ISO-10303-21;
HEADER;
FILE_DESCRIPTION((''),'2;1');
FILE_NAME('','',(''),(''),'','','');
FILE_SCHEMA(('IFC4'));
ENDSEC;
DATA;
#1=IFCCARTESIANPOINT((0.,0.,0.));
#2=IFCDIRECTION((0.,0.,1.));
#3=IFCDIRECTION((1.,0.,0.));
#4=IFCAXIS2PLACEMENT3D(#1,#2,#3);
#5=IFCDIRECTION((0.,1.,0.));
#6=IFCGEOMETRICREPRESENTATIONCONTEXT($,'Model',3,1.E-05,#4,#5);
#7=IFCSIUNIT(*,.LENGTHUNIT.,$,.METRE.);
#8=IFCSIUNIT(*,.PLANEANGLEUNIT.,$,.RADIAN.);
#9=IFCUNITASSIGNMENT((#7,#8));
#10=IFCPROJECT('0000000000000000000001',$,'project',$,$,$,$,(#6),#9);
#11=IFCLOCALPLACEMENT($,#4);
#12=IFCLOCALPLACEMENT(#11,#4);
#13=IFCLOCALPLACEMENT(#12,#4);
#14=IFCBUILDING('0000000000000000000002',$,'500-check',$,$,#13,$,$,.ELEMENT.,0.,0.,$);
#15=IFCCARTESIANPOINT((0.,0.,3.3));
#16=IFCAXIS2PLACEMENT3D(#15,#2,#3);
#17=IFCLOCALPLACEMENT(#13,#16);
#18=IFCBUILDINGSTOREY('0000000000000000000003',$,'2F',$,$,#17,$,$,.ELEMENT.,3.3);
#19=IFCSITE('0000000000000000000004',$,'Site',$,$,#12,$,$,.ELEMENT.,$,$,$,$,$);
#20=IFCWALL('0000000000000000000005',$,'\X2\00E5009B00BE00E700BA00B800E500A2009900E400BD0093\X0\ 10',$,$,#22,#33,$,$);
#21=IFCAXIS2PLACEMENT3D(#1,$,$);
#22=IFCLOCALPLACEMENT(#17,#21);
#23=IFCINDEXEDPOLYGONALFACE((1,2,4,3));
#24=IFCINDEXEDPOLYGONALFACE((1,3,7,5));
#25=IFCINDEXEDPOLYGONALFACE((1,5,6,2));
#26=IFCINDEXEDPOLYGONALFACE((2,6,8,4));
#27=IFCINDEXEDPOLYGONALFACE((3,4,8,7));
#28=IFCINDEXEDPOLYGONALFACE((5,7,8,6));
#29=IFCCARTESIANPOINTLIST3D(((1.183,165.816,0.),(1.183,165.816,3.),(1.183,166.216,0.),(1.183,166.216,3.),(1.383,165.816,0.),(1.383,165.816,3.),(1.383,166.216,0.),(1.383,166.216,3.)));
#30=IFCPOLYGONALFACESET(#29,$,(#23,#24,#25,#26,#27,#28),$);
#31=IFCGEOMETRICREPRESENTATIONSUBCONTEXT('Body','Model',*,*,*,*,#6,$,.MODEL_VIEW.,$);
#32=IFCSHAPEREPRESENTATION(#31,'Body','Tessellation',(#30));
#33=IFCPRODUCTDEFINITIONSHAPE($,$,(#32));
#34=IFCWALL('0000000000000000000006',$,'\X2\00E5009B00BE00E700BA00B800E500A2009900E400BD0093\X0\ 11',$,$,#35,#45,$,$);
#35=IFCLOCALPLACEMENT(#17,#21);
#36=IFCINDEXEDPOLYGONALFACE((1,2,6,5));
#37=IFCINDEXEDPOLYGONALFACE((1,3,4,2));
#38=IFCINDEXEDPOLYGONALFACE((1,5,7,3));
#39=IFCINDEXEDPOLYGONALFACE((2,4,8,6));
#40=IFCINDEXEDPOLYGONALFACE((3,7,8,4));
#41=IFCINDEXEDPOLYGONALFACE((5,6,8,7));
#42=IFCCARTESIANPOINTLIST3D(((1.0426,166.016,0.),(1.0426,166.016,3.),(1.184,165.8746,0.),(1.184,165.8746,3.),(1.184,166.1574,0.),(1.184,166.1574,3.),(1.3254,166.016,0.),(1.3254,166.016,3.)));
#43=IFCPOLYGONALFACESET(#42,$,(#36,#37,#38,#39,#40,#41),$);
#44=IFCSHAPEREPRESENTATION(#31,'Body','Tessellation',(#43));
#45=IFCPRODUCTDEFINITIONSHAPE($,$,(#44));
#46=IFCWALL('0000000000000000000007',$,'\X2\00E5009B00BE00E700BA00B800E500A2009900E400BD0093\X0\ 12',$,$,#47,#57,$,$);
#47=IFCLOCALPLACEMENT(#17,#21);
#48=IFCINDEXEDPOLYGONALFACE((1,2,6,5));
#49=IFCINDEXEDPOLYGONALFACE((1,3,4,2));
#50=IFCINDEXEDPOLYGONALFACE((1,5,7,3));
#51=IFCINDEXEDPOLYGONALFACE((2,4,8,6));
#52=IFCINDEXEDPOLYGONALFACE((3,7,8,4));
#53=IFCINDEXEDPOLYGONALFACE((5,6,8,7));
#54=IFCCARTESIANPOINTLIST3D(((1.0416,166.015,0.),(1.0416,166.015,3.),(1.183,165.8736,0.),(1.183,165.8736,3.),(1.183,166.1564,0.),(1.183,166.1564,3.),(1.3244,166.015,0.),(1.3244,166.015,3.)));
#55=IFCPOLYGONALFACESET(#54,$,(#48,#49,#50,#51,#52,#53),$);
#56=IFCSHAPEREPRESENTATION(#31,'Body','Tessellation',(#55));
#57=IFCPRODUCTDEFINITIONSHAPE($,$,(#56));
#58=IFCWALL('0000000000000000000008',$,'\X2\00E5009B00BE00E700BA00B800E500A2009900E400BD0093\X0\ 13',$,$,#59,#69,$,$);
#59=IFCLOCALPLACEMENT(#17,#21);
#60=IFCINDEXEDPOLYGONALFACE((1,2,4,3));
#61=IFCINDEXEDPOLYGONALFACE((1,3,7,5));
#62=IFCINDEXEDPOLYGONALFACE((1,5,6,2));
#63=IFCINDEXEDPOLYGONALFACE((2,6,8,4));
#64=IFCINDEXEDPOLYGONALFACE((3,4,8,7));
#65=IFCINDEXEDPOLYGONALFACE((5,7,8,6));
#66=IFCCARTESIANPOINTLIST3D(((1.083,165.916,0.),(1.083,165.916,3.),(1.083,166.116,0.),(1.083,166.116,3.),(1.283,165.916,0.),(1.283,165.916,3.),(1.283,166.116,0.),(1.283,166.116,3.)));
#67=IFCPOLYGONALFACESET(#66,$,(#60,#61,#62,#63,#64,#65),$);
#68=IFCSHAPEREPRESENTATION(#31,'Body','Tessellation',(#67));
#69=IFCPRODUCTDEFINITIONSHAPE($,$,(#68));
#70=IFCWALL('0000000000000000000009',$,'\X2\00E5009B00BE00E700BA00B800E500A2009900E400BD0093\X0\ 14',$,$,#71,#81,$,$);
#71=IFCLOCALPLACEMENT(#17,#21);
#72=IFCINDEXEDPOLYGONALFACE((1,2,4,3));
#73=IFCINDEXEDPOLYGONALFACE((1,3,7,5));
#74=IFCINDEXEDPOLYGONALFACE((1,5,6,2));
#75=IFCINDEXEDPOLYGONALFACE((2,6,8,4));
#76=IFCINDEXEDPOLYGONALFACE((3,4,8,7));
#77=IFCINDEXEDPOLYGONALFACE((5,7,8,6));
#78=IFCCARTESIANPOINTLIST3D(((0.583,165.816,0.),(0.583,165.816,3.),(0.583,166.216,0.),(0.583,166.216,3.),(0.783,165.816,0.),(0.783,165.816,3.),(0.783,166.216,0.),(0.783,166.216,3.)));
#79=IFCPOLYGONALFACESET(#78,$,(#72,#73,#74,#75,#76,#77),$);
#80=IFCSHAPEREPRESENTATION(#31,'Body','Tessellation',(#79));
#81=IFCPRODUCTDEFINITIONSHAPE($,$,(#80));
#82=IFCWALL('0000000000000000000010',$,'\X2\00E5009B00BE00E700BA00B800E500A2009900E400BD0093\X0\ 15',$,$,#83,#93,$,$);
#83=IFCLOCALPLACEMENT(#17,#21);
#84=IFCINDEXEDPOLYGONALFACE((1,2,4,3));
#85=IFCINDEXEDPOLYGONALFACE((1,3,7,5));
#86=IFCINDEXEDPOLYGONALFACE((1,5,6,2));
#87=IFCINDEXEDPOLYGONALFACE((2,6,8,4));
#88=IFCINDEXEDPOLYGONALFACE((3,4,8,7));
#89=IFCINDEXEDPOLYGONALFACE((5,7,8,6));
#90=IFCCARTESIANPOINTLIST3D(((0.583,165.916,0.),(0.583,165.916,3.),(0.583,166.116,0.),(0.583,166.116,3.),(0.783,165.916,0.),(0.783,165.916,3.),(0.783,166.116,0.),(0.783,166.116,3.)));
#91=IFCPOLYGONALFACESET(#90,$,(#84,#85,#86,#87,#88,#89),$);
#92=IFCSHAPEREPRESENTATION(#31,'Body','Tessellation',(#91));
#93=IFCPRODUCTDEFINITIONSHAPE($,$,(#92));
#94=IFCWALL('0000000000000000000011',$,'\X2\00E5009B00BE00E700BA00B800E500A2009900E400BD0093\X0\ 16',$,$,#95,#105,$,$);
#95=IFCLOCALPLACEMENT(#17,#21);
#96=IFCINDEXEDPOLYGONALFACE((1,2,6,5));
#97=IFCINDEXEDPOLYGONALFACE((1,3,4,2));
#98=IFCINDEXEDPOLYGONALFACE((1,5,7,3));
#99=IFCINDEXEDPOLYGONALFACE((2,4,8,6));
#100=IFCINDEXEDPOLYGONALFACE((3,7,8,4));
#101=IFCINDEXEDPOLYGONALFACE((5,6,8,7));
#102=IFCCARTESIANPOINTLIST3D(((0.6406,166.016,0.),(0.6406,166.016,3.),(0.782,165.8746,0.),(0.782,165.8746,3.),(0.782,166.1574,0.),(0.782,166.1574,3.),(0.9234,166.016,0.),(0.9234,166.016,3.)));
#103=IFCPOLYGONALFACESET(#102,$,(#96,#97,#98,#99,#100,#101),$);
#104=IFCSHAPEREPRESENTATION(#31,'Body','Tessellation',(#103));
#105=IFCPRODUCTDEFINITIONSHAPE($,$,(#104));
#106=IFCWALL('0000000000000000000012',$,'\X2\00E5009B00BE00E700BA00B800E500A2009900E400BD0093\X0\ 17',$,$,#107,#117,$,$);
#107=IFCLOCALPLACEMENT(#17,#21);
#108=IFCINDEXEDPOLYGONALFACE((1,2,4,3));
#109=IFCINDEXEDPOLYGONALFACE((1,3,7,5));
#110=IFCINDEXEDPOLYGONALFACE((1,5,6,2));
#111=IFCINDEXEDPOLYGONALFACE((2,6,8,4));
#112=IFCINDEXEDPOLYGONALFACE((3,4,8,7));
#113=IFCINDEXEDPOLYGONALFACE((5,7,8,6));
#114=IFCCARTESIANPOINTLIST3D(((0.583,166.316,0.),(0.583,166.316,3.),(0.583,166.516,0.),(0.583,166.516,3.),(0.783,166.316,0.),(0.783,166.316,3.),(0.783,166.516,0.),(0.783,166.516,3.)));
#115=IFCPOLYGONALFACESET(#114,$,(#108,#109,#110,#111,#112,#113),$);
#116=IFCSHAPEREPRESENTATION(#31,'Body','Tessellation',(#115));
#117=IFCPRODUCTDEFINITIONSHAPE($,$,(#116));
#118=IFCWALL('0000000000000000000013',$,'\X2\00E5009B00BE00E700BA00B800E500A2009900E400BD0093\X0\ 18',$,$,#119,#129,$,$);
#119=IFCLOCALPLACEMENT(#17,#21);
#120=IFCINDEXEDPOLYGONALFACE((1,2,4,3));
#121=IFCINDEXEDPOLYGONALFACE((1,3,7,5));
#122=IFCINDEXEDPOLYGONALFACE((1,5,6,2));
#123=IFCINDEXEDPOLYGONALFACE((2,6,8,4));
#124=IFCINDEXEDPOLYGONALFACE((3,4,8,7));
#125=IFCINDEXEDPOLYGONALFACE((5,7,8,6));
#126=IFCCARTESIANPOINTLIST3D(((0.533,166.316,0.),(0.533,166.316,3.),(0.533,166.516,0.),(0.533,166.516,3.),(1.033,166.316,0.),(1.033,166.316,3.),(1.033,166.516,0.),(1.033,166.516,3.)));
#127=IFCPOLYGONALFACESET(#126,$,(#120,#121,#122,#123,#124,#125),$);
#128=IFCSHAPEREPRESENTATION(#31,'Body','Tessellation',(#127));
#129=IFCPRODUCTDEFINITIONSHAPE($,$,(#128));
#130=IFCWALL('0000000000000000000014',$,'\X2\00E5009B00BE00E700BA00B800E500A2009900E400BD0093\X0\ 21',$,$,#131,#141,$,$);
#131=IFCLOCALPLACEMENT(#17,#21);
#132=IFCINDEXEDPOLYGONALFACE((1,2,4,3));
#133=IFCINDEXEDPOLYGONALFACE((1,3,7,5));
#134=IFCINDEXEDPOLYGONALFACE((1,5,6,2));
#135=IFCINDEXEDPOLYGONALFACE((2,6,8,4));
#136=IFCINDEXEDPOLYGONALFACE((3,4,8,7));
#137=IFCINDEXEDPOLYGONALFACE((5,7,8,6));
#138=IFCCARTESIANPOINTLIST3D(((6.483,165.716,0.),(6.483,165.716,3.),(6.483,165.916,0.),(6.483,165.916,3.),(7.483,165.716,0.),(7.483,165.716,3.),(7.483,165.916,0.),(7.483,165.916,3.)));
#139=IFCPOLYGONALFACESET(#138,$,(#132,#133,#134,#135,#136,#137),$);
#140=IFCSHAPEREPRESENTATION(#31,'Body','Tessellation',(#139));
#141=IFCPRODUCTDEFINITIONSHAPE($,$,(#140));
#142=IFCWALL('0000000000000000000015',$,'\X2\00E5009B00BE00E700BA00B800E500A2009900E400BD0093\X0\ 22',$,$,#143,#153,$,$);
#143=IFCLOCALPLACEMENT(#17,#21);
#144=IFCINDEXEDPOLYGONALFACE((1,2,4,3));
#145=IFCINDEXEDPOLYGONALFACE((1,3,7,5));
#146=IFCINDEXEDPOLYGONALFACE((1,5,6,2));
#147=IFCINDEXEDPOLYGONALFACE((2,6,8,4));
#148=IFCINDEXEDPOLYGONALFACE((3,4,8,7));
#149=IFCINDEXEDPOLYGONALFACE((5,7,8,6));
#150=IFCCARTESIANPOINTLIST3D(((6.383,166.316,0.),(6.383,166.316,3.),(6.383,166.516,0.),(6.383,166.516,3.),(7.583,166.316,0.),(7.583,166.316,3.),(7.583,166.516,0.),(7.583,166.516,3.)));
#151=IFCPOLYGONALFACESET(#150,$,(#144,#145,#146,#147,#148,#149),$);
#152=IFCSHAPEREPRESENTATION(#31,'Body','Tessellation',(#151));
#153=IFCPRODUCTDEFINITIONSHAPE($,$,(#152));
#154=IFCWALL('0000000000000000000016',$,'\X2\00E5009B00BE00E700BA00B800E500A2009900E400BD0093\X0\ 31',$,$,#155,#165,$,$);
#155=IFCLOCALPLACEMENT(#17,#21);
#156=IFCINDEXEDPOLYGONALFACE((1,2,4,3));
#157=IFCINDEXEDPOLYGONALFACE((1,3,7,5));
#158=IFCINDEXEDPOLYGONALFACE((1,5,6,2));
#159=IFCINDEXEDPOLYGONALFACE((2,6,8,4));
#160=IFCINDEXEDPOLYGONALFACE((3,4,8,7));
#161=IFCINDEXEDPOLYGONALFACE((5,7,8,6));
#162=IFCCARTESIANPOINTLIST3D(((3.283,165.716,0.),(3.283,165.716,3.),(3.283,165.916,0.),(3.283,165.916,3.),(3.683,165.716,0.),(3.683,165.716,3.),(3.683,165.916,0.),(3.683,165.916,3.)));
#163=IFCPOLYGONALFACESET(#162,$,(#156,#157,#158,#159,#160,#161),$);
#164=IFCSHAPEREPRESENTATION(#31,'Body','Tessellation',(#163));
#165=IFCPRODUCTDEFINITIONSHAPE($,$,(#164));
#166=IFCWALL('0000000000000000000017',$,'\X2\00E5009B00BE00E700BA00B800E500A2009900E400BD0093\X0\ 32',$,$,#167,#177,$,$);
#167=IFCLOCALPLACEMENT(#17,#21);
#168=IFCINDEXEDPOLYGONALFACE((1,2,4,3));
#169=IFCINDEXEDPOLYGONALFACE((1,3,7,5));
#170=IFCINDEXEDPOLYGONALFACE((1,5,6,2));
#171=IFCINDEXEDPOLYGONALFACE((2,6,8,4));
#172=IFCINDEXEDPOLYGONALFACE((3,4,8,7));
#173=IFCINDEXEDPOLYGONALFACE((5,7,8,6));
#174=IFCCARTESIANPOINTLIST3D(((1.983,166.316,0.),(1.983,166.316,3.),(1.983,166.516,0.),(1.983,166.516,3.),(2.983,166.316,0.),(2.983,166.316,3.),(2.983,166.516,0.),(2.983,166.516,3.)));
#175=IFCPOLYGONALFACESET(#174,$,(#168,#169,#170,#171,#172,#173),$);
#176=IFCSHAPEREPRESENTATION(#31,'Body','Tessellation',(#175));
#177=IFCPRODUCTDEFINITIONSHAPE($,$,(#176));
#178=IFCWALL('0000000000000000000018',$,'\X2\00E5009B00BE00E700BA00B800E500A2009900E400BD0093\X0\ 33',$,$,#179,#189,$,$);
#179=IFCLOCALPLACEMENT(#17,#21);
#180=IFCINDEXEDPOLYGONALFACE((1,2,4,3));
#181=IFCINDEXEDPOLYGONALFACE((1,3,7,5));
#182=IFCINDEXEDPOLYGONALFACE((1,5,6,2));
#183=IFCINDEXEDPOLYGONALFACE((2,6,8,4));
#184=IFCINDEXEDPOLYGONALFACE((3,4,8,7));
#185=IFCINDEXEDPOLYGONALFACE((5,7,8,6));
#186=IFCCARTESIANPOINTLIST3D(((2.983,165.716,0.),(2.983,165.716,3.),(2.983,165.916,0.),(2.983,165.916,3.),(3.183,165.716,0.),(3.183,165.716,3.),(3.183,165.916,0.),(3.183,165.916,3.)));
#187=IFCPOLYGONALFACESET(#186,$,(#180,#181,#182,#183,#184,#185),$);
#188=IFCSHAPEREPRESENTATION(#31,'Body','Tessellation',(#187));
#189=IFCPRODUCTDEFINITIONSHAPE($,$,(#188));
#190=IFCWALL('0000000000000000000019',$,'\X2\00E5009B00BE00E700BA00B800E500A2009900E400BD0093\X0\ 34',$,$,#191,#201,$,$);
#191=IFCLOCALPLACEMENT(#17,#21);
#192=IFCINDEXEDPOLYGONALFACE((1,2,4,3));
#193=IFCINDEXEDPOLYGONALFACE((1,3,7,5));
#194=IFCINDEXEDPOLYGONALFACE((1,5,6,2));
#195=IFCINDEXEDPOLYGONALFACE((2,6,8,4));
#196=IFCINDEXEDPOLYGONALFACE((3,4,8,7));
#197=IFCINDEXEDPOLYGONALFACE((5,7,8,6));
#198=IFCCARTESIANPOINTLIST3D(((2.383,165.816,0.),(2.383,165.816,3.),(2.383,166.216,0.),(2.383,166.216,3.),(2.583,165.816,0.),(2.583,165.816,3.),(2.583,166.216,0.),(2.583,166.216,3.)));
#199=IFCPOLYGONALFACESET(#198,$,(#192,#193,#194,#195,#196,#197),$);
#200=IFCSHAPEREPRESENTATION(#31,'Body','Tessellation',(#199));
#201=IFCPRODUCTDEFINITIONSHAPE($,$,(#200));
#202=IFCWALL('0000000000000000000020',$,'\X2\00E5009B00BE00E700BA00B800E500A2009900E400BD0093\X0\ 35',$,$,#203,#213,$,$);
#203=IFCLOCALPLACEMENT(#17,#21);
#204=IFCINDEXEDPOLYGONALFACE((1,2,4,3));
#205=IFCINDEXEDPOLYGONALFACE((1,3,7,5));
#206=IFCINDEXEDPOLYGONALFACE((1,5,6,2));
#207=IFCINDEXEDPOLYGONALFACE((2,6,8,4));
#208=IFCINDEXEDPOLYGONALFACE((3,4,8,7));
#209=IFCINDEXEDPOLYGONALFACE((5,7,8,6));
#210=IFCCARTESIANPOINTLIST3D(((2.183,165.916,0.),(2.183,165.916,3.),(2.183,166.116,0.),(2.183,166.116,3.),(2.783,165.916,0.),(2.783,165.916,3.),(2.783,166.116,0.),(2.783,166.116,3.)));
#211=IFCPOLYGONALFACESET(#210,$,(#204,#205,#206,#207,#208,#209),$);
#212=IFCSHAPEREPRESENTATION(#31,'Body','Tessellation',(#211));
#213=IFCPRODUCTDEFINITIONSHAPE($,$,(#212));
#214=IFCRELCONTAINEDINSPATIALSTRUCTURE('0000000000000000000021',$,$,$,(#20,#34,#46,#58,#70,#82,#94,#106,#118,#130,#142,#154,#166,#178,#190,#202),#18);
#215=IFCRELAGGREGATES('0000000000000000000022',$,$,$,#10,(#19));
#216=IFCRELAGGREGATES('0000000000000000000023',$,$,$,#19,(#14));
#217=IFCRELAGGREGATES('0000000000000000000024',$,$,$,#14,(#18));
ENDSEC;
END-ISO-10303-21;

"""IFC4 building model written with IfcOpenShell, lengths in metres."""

from ifc_helpers import new_model, si_unit, direction, frame, frame_2d, origin_with_axes, place, context, subcontext, project, spatial, rectangle, extrude, element, save


model = new_model("IFC4")

# Units and contexts
model_context = context("Model", 3, precision=1e-05, world=origin_with_axes(), true_north=direction((0.0, 1.0, 0.0)))
body_context = subcontext(model_context, "Body", "Model", "MODEL_VIEW")
ifc_project = project(units=[si_unit("LENGTHUNIT", "METRE"), si_unit("PLANEANGLEUNIT", "RADIAN")], contexts=[model_context])

# Site, building, storey
placement = place(None, origin_with_axes())
site_placement = place(placement, origin_with_axes())
site = spatial("IfcSite", under=ifc_project, at=site_placement, Name="Site", CompositionType="ELEMENT")
building_placement = place(site_placement, origin_with_axes())
building = spatial("IfcBuilding", under=site, at=building_placement, Name="500-check", CompositionType="ELEMENT", ElevationOfRefHeight=0.0, ElevationOfTerrain=0.0)
storey_placement = place(building_placement, frame((0.0, 0.0, 3.3), z_axis=(0.0, 0.0, 1.0), x_axis=(1.0, 0.0, 0.0)))
storey = spatial("IfcBuildingStorey", under=building, at=storey_placement, Name="2F", CompositionType="ELEMENT", Elevation=3.3)

# Walls
wall_1_placement = place(storey_placement, frame((1.283, 166.016, 0.0), z_axis=(0.0, 0.0, 1.0), x_axis=(0.0, 1.0, 0.0)))
element("IfcWall", 1, at=wall_1_placement, inside=storey, Name="å\u009b¾çº¸å¢\u0099ä½\u0093 10", context=body_context, shape_type="SweptSolid", body=[
    extrude(rectangle(XDim=0.4, YDim=0.2, at=frame_2d((0.0, 0.0), x_axis=(1.0, 0.0, 0.0))), frame((0.0, 0.0, 0.0), z_axis=(0.0, 0.0, 1.0)), (0.0, 0.0, 1.0), 3.0),
])
for number, where, z_axis, x_axis, name in (
    (2, (1.184, 166.016, 0.0), (0.0, 0.0, 1.0), (-0.707107, -0.707107, 0.0), "å\u009b¾çº¸å¢\u0099ä½\u0093 11"),
    (3, (1.183, 166.015, 0.0), (0.0, 0.0, 1.0), (0.707107, 0.707107, 0.0), "å\u009b¾çº¸å¢\u0099ä½\u0093 12"),
    (4, (1.183, 166.016, 0.0), (0.0, 0.0, 1.0), (1.0, 0.0, 0.0), "å\u009b¾çº¸å¢\u0099ä½\u0093 13"),
):
    element("IfcWall", number, at=place(storey_placement, frame(where, z_axis=z_axis, x_axis=x_axis)), inside=storey, Name=name, context=body_context, shape_type="SweptSolid", body=[
        extrude(rectangle(XDim=0.2, YDim=0.2, at=frame_2d((0.0, 0.0), x_axis=(1.0, 0.0, 0.0))), frame((0.0, 0.0, 0.0), z_axis=(0.0, 0.0, 1.0)), (0.0, 0.0, 1.0), 3.0),
    ])
wall_2_placement = place(storey_placement, frame((0.683, 166.016, 0.0), z_axis=(0.0, 0.0, 1.0), x_axis=(0.0, 1.0, 0.0)))
element("IfcWall", 5, at=wall_2_placement, inside=storey, Name="å\u009b¾çº¸å¢\u0099ä½\u0093 14", context=body_context, shape_type="SweptSolid", body=[
    extrude(rectangle(XDim=0.4, YDim=0.2, at=frame_2d((0.0, 0.0), x_axis=(1.0, 0.0, 0.0))), frame((0.0, 0.0, 0.0), z_axis=(0.0, 0.0, 1.0)), (0.0, 0.0, 1.0), 3.0),
])
for number, where, z_axis, x_axis, name in (
    (6, (0.683, 166.016, 0.0), (0.0, 0.0, 1.0), (1.0, 0.0, 0.0), "å\u009b¾çº¸å¢\u0099ä½\u0093 15"),
    (7, (0.782, 166.016, 0.0), (0.0, 0.0, 1.0), (0.707107, -0.707107, 0.0), "å\u009b¾çº¸å¢\u0099ä½\u0093 16"),
    (8, (0.683, 166.416, 0.0), (0.0, 0.0, 1.0), (1.0, 0.0, 0.0), "å\u009b¾çº¸å¢\u0099ä½\u0093 17"),
):
    element("IfcWall", number, at=place(storey_placement, frame(where, z_axis=z_axis, x_axis=x_axis)), inside=storey, Name=name, context=body_context, shape_type="SweptSolid", body=[
        extrude(rectangle(XDim=0.2, YDim=0.2, at=frame_2d((0.0, 0.0), x_axis=(1.0, 0.0, 0.0))), frame((0.0, 0.0, 0.0), z_axis=(0.0, 0.0, 1.0)), (0.0, 0.0, 1.0), 3.0),
    ])
wall_3_placement = place(storey_placement, frame((0.783, 166.416, 0.0), z_axis=(0.0, 0.0, 1.0), x_axis=(1.0, 0.0, 0.0)))
element("IfcWall", 9, at=wall_3_placement, inside=storey, Name="å\u009b¾çº¸å¢\u0099ä½\u0093 18", context=body_context, shape_type="SweptSolid", body=[
    extrude(rectangle(XDim=0.5, YDim=0.2, at=frame_2d((0.0, 0.0), x_axis=(1.0, 0.0, 0.0))), frame((0.0, 0.0, 0.0), z_axis=(0.0, 0.0, 1.0)), (0.0, 0.0, 1.0), 3.0),
])
wall_4_placement = place(storey_placement, frame((6.983, 165.816, 0.0), z_axis=(0.0, 0.0, 1.0), x_axis=(1.0, 0.0, 0.0)))
element("IfcWall", 10, at=wall_4_placement, inside=storey, Name="å\u009b¾çº¸å¢\u0099ä½\u0093 21", context=body_context, shape_type="SweptSolid", body=[
    extrude(rectangle(XDim=1.0, YDim=0.2, at=frame_2d((0.0, 0.0), x_axis=(1.0, 0.0, 0.0))), frame((0.0, 0.0, 0.0), z_axis=(0.0, 0.0, 1.0)), (0.0, 0.0, 1.0), 3.0),
])
wall_5_placement = place(storey_placement, frame((6.983, 166.416, 0.0), z_axis=(0.0, 0.0, 1.0), x_axis=(1.0, 0.0, 0.0)))
element("IfcWall", 11, at=wall_5_placement, inside=storey, Name="å\u009b¾çº¸å¢\u0099ä½\u0093 22", context=body_context, shape_type="SweptSolid", body=[
    extrude(rectangle(XDim=1.2, YDim=0.2, at=frame_2d((0.0, 0.0), x_axis=(1.0, 0.0, 0.0))), frame((0.0, 0.0, 0.0), z_axis=(0.0, 0.0, 1.0)), (0.0, 0.0, 1.0), 3.0),
])
wall_6_placement = place(storey_placement, frame((3.483, 165.816, 0.0), z_axis=(0.0, 0.0, 1.0), x_axis=(-1.0, 0.0, 0.0)))
element("IfcWall", 12, at=wall_6_placement, inside=storey, Name="å\u009b¾çº¸å¢\u0099ä½\u0093 31", context=body_context, shape_type="SweptSolid", body=[
    extrude(rectangle(XDim=0.4, YDim=0.2, at=frame_2d((0.0, 0.0), x_axis=(1.0, 0.0, 0.0))), frame((0.0, 0.0, 0.0), z_axis=(0.0, 0.0, 1.0)), (0.0, 0.0, 1.0), 3.0),
])
wall_7_placement = place(storey_placement, frame((2.483, 166.416, 0.0), z_axis=(0.0, 0.0, 1.0), x_axis=(1.0, 0.0, 0.0)))
element("IfcWall", 13, at=wall_7_placement, inside=storey, Name="å\u009b¾çº¸å¢\u0099ä½\u0093 32", context=body_context, shape_type="SweptSolid", body=[
    extrude(rectangle(XDim=1.0, YDim=0.2, at=frame_2d((0.0, 0.0), x_axis=(1.0, 0.0, 0.0))), frame((0.0, 0.0, 0.0), z_axis=(0.0, 0.0, 1.0)), (0.0, 0.0, 1.0), 3.0),
])
wall_8_placement = place(storey_placement, frame((3.083, 165.816, 0.0), z_axis=(0.0, 0.0, 1.0), x_axis=(0.0, 1.0, 0.0)))
element("IfcWall", 14, at=wall_8_placement, inside=storey, Name="å\u009b¾çº¸å¢\u0099ä½\u0093 33", context=body_context, shape_type="SweptSolid", body=[
    extrude(rectangle(XDim=0.2, YDim=0.2, at=frame_2d((0.0, 0.0), x_axis=(1.0, 0.0, 0.0))), frame((0.0, 0.0, 0.0), z_axis=(0.0, 0.0, 1.0)), (0.0, 0.0, 1.0), 3.0),
])
wall_9_placement = place(storey_placement, frame((2.483, 166.016, 0.0), z_axis=(0.0, 0.0, 1.0), x_axis=(0.0, 1.0, 0.0)))
element("IfcWall", 15, at=wall_9_placement, inside=storey, Name="å\u009b¾çº¸å¢\u0099ä½\u0093 34", context=body_context, shape_type="SweptSolid", body=[
    extrude(rectangle(XDim=0.4, YDim=0.2, at=frame_2d((0.0, 0.0), x_axis=(1.0, 0.0, 0.0))), frame((0.0, 0.0, 0.0), z_axis=(0.0, 0.0, 1.0)), (0.0, 0.0, 1.0), 3.0),
])
for number, where, z_axis, x_axis, name in (
    (16, (2.483, 166.016, 0.0), (0.0, 0.0, 1.0), (1.0, 0.0, 0.0), "å\u009b¾çº¸å¢\u0099ä½\u0093 35"),
):
    element("IfcWall", number, at=place(storey_placement, frame(where, z_axis=z_axis, x_axis=x_axis)), inside=storey, Name=name, context=body_context, shape_type="SweptSolid", body=[
        extrude(rectangle(XDim=0.6, YDim=0.2, at=frame_2d((0.0, 0.0), x_axis=(1.0, 0.0, 0.0))), frame((0.0, 0.0, 0.0), z_axis=(0.0, 0.0, 1.0)), (0.0, 0.0, 1.0), 3.0),
    ])

save(model, "model.ifc")
